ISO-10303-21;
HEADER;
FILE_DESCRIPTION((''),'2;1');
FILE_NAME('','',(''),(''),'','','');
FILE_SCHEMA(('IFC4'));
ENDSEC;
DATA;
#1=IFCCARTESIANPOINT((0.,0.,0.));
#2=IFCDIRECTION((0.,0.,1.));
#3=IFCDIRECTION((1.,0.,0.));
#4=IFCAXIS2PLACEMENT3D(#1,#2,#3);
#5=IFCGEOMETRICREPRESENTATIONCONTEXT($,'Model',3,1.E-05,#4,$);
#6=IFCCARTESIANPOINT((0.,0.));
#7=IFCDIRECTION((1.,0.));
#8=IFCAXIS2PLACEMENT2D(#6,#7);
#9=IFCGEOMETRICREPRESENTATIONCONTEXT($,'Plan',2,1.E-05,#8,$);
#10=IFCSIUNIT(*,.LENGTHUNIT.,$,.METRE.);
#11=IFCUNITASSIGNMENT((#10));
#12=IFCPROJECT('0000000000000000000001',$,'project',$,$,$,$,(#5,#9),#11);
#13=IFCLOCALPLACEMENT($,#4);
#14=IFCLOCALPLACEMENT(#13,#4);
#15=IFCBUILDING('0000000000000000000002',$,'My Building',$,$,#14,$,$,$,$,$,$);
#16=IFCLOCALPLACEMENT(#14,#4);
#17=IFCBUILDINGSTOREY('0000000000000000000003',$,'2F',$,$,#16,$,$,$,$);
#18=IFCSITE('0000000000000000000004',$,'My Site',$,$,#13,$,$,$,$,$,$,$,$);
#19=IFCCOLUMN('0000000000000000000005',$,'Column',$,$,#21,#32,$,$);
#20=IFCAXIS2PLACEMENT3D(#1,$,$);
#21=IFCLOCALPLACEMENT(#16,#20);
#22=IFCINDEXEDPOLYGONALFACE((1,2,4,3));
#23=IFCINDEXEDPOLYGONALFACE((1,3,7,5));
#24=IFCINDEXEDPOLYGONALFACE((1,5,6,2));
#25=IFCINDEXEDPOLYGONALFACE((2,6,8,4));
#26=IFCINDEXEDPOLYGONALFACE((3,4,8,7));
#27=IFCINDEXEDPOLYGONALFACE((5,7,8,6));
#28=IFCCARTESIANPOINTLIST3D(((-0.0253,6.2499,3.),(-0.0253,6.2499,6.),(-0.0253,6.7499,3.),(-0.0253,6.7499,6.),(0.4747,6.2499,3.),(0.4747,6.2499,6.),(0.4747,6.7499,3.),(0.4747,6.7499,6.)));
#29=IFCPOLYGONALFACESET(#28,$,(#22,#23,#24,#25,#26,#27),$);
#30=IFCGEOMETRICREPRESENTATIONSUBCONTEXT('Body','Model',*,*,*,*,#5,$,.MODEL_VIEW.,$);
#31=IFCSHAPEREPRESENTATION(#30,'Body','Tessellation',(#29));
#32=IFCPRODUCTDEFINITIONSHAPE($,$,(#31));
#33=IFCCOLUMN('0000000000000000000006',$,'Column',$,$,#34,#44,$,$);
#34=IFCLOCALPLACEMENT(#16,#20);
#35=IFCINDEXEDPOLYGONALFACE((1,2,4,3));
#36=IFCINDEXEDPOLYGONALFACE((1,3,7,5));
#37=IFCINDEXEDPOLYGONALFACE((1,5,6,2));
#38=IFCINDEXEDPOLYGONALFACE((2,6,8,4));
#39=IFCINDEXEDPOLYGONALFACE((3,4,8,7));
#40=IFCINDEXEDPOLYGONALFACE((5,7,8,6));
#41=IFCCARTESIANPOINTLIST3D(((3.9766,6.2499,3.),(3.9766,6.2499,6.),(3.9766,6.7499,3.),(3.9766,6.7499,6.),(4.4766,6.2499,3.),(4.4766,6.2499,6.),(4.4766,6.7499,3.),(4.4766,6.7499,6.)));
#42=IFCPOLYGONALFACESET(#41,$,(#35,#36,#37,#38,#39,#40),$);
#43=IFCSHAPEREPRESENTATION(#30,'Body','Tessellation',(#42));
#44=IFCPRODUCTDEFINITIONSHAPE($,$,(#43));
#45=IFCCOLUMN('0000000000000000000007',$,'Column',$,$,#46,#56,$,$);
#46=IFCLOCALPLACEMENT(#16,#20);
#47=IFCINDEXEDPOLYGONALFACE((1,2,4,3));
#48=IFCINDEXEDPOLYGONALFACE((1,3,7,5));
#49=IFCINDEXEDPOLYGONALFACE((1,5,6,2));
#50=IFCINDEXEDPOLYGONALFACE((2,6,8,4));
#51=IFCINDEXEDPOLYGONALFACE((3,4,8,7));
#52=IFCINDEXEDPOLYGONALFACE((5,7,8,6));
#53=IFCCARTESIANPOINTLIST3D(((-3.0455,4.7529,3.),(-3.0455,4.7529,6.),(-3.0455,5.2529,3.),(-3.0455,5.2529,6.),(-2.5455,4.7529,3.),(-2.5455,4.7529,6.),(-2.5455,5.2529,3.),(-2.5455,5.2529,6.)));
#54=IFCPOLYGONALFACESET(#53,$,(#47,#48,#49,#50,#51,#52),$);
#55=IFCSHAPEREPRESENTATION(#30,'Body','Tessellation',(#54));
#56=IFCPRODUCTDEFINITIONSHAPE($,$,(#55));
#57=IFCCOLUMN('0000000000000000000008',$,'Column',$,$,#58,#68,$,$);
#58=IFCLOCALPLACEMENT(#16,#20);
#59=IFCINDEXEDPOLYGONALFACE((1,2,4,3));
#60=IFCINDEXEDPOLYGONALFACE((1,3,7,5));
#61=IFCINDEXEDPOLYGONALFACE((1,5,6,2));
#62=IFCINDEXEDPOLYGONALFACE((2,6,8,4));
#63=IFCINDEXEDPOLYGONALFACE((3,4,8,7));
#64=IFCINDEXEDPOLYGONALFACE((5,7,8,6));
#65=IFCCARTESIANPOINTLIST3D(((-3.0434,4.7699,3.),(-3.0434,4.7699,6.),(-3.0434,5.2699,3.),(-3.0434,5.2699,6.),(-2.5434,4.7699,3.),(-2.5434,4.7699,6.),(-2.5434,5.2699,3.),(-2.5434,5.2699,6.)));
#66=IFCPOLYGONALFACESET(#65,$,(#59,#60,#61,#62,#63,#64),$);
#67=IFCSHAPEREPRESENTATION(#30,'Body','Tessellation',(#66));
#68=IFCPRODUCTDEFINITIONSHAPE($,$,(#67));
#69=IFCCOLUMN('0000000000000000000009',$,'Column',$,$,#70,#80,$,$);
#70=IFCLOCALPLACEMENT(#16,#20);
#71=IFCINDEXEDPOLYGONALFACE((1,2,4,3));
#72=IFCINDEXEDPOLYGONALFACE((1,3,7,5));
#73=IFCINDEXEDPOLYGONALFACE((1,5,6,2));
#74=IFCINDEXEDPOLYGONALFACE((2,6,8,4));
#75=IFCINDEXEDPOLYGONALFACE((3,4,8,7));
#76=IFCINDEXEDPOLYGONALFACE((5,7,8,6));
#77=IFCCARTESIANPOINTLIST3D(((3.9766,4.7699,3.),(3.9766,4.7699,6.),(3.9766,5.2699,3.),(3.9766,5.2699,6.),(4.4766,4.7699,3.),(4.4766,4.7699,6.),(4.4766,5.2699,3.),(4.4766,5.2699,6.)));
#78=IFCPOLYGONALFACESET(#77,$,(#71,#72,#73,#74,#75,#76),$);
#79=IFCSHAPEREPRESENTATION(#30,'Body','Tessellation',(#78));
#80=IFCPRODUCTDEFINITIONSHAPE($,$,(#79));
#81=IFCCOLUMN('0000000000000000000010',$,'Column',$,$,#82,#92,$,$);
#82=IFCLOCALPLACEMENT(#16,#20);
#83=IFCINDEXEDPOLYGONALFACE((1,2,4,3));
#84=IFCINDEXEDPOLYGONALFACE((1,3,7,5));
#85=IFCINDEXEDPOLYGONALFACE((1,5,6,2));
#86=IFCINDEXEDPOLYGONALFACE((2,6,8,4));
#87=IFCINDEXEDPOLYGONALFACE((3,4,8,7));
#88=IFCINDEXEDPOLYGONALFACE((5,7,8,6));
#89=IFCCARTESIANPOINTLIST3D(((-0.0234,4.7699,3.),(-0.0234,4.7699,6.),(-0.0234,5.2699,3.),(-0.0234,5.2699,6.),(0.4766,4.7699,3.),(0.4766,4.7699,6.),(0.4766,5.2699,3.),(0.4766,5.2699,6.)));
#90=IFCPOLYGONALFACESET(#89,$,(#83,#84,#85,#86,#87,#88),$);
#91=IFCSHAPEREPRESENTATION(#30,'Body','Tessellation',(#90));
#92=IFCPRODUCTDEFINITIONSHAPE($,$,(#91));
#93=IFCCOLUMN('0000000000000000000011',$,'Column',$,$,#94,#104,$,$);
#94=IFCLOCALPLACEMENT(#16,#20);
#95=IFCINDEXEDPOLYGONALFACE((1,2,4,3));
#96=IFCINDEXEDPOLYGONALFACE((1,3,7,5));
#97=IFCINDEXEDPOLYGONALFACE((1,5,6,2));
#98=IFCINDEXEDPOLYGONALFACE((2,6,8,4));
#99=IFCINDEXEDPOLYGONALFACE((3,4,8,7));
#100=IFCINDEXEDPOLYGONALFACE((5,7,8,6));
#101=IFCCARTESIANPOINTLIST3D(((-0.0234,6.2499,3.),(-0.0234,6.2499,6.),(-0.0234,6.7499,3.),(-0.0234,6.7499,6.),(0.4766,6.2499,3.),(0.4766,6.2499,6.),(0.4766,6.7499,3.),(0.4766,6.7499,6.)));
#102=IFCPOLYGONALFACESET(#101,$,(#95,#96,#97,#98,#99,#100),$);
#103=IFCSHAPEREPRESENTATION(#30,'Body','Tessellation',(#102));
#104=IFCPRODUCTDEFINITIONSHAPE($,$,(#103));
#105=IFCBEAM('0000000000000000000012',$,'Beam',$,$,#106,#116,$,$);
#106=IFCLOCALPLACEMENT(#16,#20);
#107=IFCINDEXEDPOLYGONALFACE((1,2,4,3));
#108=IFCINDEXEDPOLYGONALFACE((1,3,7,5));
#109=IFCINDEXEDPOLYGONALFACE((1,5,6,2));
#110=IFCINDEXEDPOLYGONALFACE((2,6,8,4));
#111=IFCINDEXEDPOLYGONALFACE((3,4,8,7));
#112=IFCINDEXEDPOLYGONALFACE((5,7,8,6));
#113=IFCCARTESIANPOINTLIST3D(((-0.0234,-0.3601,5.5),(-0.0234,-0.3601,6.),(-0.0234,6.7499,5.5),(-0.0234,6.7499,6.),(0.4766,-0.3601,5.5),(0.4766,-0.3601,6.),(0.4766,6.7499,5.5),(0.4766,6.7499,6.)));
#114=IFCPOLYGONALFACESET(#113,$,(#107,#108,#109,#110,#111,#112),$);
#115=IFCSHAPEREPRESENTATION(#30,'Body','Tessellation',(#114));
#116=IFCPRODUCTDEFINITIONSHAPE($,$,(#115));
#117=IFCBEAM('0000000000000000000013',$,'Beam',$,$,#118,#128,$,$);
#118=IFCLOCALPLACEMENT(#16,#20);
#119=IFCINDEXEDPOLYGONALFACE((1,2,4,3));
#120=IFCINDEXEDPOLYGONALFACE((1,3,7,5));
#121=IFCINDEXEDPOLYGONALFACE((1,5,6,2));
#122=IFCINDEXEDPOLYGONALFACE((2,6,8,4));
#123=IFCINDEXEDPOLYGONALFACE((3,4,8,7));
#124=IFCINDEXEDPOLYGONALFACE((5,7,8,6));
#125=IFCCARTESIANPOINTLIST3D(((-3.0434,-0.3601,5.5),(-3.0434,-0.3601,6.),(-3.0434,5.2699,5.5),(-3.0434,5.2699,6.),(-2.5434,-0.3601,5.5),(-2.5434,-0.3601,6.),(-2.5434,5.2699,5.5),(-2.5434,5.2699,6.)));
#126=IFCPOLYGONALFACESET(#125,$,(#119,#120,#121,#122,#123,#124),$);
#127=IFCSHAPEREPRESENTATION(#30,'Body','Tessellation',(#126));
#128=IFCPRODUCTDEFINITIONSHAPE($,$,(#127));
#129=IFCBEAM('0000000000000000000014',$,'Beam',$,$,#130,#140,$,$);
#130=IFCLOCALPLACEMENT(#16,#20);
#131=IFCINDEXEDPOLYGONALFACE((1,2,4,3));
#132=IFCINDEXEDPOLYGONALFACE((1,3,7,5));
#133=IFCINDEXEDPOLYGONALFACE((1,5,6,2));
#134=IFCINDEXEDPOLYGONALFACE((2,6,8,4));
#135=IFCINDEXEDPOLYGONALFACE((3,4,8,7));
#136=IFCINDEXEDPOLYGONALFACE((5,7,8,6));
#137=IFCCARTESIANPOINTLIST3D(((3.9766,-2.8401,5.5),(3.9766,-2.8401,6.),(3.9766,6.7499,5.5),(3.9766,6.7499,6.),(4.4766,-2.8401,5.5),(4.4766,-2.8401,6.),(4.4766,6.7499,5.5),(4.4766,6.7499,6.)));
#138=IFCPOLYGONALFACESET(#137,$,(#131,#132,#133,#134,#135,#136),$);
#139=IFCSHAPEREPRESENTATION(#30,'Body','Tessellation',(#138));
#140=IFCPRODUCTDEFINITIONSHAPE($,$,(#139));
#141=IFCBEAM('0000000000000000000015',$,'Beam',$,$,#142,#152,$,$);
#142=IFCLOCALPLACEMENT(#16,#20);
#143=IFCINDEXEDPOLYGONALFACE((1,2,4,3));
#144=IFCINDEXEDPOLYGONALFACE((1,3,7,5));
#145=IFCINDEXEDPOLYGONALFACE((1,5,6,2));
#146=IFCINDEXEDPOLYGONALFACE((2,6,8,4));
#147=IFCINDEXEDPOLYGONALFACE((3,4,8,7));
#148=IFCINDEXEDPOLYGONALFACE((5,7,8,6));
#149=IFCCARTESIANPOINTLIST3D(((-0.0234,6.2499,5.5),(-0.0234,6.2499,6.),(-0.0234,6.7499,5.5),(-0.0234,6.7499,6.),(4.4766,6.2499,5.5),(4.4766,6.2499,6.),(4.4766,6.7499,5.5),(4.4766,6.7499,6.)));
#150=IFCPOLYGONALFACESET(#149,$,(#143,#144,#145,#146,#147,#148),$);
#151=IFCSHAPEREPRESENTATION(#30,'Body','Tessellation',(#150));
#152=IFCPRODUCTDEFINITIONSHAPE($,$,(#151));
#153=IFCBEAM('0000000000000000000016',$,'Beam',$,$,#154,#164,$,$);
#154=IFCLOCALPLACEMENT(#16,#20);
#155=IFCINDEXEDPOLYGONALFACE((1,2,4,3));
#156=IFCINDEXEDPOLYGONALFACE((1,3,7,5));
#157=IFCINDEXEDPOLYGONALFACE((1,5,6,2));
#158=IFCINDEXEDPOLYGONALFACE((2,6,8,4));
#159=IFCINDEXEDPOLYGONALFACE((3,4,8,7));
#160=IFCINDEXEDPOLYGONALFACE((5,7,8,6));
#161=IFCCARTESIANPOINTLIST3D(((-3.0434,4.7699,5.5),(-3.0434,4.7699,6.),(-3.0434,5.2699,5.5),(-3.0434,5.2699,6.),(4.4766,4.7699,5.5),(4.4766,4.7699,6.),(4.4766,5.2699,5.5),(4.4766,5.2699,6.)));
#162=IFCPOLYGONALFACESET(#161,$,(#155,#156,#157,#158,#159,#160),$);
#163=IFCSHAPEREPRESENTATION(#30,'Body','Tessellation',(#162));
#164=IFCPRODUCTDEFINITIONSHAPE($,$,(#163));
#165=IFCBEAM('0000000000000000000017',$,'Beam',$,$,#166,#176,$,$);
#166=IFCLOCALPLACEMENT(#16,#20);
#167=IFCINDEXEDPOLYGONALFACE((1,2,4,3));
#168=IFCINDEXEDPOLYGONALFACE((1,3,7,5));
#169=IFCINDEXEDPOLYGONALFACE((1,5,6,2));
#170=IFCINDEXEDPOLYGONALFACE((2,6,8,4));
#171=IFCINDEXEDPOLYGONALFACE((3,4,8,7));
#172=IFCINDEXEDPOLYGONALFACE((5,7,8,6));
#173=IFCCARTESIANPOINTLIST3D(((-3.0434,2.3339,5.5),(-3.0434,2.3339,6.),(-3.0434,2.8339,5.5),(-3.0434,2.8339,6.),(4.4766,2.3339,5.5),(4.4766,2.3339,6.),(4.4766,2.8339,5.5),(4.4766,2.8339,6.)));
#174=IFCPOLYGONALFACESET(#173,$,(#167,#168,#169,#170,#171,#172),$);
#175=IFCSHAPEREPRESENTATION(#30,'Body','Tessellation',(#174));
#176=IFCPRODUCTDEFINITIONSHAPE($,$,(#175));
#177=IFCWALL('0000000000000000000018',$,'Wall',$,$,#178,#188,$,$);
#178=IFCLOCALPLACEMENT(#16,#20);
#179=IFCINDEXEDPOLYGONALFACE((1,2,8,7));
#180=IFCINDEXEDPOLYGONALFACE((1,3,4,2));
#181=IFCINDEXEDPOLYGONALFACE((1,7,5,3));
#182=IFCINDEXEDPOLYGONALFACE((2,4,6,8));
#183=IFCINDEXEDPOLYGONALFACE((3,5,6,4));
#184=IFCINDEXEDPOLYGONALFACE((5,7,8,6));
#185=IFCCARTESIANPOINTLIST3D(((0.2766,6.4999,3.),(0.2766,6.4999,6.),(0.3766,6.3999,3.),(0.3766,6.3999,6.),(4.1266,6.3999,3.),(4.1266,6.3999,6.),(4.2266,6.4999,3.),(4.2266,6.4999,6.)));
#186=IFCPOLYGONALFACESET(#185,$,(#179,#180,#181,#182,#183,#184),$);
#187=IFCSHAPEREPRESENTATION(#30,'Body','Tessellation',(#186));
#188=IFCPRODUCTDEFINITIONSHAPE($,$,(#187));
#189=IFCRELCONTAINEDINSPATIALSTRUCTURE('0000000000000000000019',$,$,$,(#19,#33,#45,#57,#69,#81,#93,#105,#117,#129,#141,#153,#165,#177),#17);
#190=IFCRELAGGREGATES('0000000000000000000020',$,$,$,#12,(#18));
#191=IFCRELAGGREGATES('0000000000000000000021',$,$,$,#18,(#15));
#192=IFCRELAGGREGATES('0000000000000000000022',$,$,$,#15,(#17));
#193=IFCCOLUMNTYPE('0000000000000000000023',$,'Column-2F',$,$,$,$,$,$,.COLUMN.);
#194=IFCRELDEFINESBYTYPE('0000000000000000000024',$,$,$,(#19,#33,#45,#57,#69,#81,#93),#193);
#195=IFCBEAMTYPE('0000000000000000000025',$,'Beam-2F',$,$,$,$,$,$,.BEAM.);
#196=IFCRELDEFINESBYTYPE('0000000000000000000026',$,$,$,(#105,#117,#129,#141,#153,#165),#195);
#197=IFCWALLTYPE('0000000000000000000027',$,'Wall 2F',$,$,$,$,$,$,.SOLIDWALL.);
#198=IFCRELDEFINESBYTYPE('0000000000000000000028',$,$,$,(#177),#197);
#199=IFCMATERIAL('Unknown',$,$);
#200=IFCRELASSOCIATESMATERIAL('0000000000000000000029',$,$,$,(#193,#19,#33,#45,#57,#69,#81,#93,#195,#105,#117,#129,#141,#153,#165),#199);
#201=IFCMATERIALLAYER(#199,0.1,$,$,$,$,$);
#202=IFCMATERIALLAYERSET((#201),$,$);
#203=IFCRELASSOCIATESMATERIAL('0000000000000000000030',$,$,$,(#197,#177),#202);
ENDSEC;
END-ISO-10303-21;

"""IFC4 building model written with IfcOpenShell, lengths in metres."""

from ifc_helpers import new_model, si_unit, frame, origin_with_axes, origin_2d_with_axis, place, context, subcontext, project, spatial, line, indexed_curve, rectangle, outline, extrude, material, layer, layer_set, layer_usage, material_profile, profile_set, profile_usage, type_object, element, save


model = new_model("IFC4")

# Units and contexts
model_context = context("Model", 3, precision=1e-05, world=origin_with_axes())
plan_context = context("Plan", 2, precision=1e-05, world=origin_2d_with_axis())
body_context_1 = subcontext(model_context, "Body", "Model", "MODEL_VIEW")
ifc_project = project(units=[si_unit("LENGTHUNIT", "METRE")], contexts=[model_context, plan_context])

# Site, building, storey
site_placement = place(None, origin_with_axes())
site = spatial("IfcSite", under=ifc_project, at=site_placement, Name="My Site")
building_placement = place(site_placement, origin_with_axes())
building = spatial("IfcBuilding", under=site, at=building_placement, Name="My Building")
storey_placement = place(building_placement, origin_with_axes())
storey = spatial("IfcBuildingStorey", under=building, at=storey_placement, Name="2F")

# Columns
ifc_material = material(Name="Unknown")
ifc_material_profile_1 = material_profile(ifc_material, rectangle(XDim=0.5, YDim=0.5))
ifc_profile_set_1 = profile_set([ifc_material_profile_1])
ifc_profile_usage_1 = profile_usage(ifc_profile_set_1, cardinal=7)
column_type = type_object("IfcColumnType", Name="Column-2F", PredefinedType="COLUMN", material=ifc_profile_set_1)
column_1_placement = place(storey_placement, frame((0.4747, 6.7499, 3.0), z_axis=(0.0, 0.0, 1.0), x_axis=(1.0, 0.0, 0.0)))
element("IfcColumn", 1, at=column_1_placement, inside=storey, type_object=column_type, material=ifc_profile_usage_1, Name="Column", context=body_context_1, shape_type="SweptSolid", body=[
    extrude(rectangle(XDim=0.5, YDim=0.5), frame((-0.25, -0.25, 0.0), z_axis=(0.0, 0.0, 1.0), x_axis=(1.0, 0.0, 0.0)), (0.0, 0.0, 1.0), 3.0),
])
ifc_profile_usage_2 = profile_usage(ifc_profile_set_1, cardinal=7)
column_2_placement = place(storey_placement, frame((4.4766, 6.7499, 3.0), z_axis=(0.0, 0.0, 1.0), x_axis=(1.0, 0.0, 0.0)))
element("IfcColumn", 2, at=column_2_placement, inside=storey, type_object=column_type, material=ifc_profile_usage_2, Name="Column", context=body_context_1, shape_type="SweptSolid", body=[
    extrude(rectangle(XDim=0.5, YDim=0.5), frame((-0.25, -0.25, 0.0), z_axis=(0.0, 0.0, 1.0), x_axis=(1.0, 0.0, 0.0)), (0.0, 0.0, 1.0), 3.0),
])
ifc_profile_usage_3 = profile_usage(ifc_profile_set_1, cardinal=7)
column_3_placement = place(storey_placement, frame((-2.5455, 5.2529, 3.0), z_axis=(0.0, 0.0, 1.0), x_axis=(1.0, 0.0, 0.0)))
element("IfcColumn", 3, at=column_3_placement, inside=storey, type_object=column_type, material=ifc_profile_usage_3, Name="Column", context=body_context_1, shape_type="SweptSolid", body=[
    extrude(rectangle(XDim=0.5, YDim=0.5), frame((-0.25, -0.25, 0.0), z_axis=(0.0, 0.0, 1.0), x_axis=(1.0, 0.0, 0.0)), (0.0, 0.0, 1.0), 3.0),
])
ifc_profile_usage_4 = profile_usage(ifc_profile_set_1, cardinal=7)
column_4_placement = place(storey_placement, frame((-2.5434, 5.2699, 3.0), z_axis=(0.0, 0.0, 1.0), x_axis=(1.0, 0.0, 0.0)))
element("IfcColumn", 4, at=column_4_placement, inside=storey, type_object=column_type, material=ifc_profile_usage_4, Name="Column", context=body_context_1, shape_type="SweptSolid", body=[
    extrude(rectangle(XDim=0.5, YDim=0.5), frame((-0.25, -0.25, 0.0), z_axis=(0.0, 0.0, 1.0), x_axis=(1.0, 0.0, 0.0)), (0.0, 0.0, 1.0), 3.0),
])
ifc_profile_usage_5 = profile_usage(ifc_profile_set_1, cardinal=7)
column_5_placement = place(storey_placement, frame((4.4766, 5.2699, 3.0), z_axis=(0.0, 0.0, 1.0), x_axis=(1.0, 0.0, 0.0)))
element("IfcColumn", 5, at=column_5_placement, inside=storey, type_object=column_type, material=ifc_profile_usage_5, Name="Column", context=body_context_1, shape_type="SweptSolid", body=[
    extrude(rectangle(XDim=0.5, YDim=0.5), frame((-0.25, -0.25, 0.0), z_axis=(0.0, 0.0, 1.0), x_axis=(1.0, 0.0, 0.0)), (0.0, 0.0, 1.0), 3.0),
])
ifc_profile_usage_6 = profile_usage(ifc_profile_set_1, cardinal=7)
column_6_placement = place(storey_placement, frame((0.4766, 5.2699, 3.0), z_axis=(0.0, 0.0, 1.0), x_axis=(1.0, 0.0, 0.0)))
element("IfcColumn", 6, at=column_6_placement, inside=storey, type_object=column_type, material=ifc_profile_usage_6, Name="Column", context=body_context_1, shape_type="SweptSolid", body=[
    extrude(rectangle(XDim=0.5, YDim=0.5), frame((-0.25, -0.25, 0.0), z_axis=(0.0, 0.0, 1.0), x_axis=(1.0, 0.0, 0.0)), (0.0, 0.0, 1.0), 3.0),
])
ifc_profile_usage_7 = profile_usage(ifc_profile_set_1, cardinal=7)
column_7_placement = place(storey_placement, frame((0.4766, 6.7499, 3.0), z_axis=(0.0, 0.0, 1.0), x_axis=(1.0, 0.0, 0.0)))
element("IfcColumn", 7, at=column_7_placement, inside=storey, type_object=column_type, material=ifc_profile_usage_7, Name="Column", context=body_context_1, shape_type="SweptSolid", body=[
    extrude(rectangle(XDim=0.5, YDim=0.5), frame((-0.25, -0.25, 0.0), z_axis=(0.0, 0.0, 1.0), x_axis=(1.0, 0.0, 0.0)), (0.0, 0.0, 1.0), 3.0),
])

# Beams
ifc_material_profile_2 = material_profile(ifc_material, rectangle(XDim=0.5, YDim=0.5))
ifc_profile_set_2 = profile_set([ifc_material_profile_2])
ifc_profile_usage_8 = profile_usage(ifc_profile_set_2, cardinal=7)
beam_type = type_object("IfcBeamType", Name="Beam-2F", PredefinedType="BEAM", material=ifc_profile_set_2)
beam_1_placement = place(storey_placement, frame((0.4766, 6.7499, 6.0), z_axis=(0.0, -1.0, 0.0), x_axis=(1.0, 0.0, 0.0)))
element("IfcBeam", 8, at=beam_1_placement, inside=storey, type_object=beam_type, material=ifc_profile_usage_8, Name="Beam", context=body_context_1, shape_type="SweptSolid", body=[
    extrude(rectangle(XDim=0.5, YDim=0.5), frame((-0.25, -0.25, 0.0), z_axis=(0.0, 0.0, 1.0), x_axis=(1.0, 0.0, 0.0)), (0.0, 0.0, 1.0), 7.11),
])
ifc_profile_usage_9 = profile_usage(ifc_profile_set_2, cardinal=7)
beam_2_placement = place(storey_placement, frame((-2.5434, 5.2699, 6.0), z_axis=(0.0, -1.0, 0.0), x_axis=(1.0, 0.0, 0.0)))
element("IfcBeam", 9, at=beam_2_placement, inside=storey, type_object=beam_type, material=ifc_profile_usage_9, Name="Beam", context=body_context_1, shape_type="SweptSolid", body=[
    extrude(rectangle(XDim=0.5, YDim=0.5), frame((-0.25, -0.25, 0.0), z_axis=(0.0, 0.0, 1.0), x_axis=(1.0, 0.0, 0.0)), (0.0, 0.0, 1.0), 5.63),
])
ifc_profile_usage_10 = profile_usage(ifc_profile_set_2, cardinal=7)
beam_3_placement = place(storey_placement, frame((4.4766, 6.7499, 6.0), z_axis=(0.0, -1.0, 0.0), x_axis=(1.0, 0.0, 0.0)))
element("IfcBeam", 10, at=beam_3_placement, inside=storey, type_object=beam_type, material=ifc_profile_usage_10, Name="Beam", context=body_context_1, shape_type="SweptSolid", body=[
    extrude(rectangle(XDim=0.5, YDim=0.5), frame((-0.25, -0.25, 0.0), z_axis=(0.0, 0.0, 1.0), x_axis=(1.0, 0.0, 0.0)), (0.0, 0.0, 1.0), 9.59),
])
ifc_profile_usage_11 = profile_usage(ifc_profile_set_2, cardinal=7)
beam_4_placement = place(storey_placement, frame((-0.0234, 6.7499, 6.0), z_axis=(1.0, 0.0, 0.0), x_axis=(0.0, 1.0, 0.0)))
element("IfcBeam", 11, at=beam_4_placement, inside=storey, type_object=beam_type, material=ifc_profile_usage_11, Name="Beam", context=body_context_1, shape_type="SweptSolid", body=[
    extrude(rectangle(XDim=0.5, YDim=0.5), frame((-0.25, -0.25, 0.0), z_axis=(0.0, 0.0, 1.0), x_axis=(1.0, 0.0, 0.0)), (0.0, 0.0, 1.0), 4.5),
])
ifc_profile_usage_12 = profile_usage(ifc_profile_set_2, cardinal=7)
beam_5_placement = place(storey_placement, frame((-3.0434, 5.2699, 6.0), z_axis=(1.0, 0.0, 0.0), x_axis=(0.0, 1.0, 0.0)))
element("IfcBeam", 12, at=beam_5_placement, inside=storey, type_object=beam_type, material=ifc_profile_usage_12, Name="Beam", context=body_context_1, shape_type="SweptSolid", body=[
    extrude(rectangle(XDim=0.5, YDim=0.5), frame((-0.25, -0.25, 0.0), z_axis=(0.0, 0.0, 1.0), x_axis=(1.0, 0.0, 0.0)), (0.0, 0.0, 1.0), 7.52),
])
ifc_profile_usage_13 = profile_usage(ifc_profile_set_2, cardinal=7)
beam_6_placement = place(storey_placement, frame((-3.0434, 2.8339, 6.0), z_axis=(1.0, -0.000001, 0.000001), x_axis=(0.000001, 1.0, 0.0)))
element("IfcBeam", 13, at=beam_6_placement, inside=storey, type_object=beam_type, material=ifc_profile_usage_13, Name="Beam", context=body_context_1, shape_type="SweptSolid", body=[
    extrude(rectangle(XDim=0.5, YDim=0.5), frame((-0.25, -0.25, 0.0), z_axis=(0.0, 0.0, 1.0), x_axis=(1.0, 0.0, 0.0)), (0.0, 0.0, 1.0), 7.52),
])

# Wall
ifc_layer = layer(ifc_material, 0.1)
ifc_layer_set = layer_set([ifc_layer])
ifc_layer_usage_1 = layer_usage(ifc_layer_set, "AXIS2", "POSITIVE", 0.0)
wall_type = type_object("IfcWallType", Name="Wall 2F", PredefinedType="SOLIDWALL", material=ifc_layer_set)
wall_1_placement = place(storey_placement, frame((4.2266, 6.4999, 3.0), z_axis=(0.0, 0.0, 1.0), x_axis=(-1.0, 0.0, 0.0)))
element("IfcWall", 14, at=wall_1_placement, inside=storey, type_object=wall_type, material=ifc_layer_usage_1, Name="Wall", context=body_context_1, shape_type="SweptSolid", body=[
    extrude(outline(indexed_curve([(0.0, 0.0), (0.1, 0.1), (3.85, 0.1), (3.95, 0.0)], segments=[line(1, 2, 3, 4, 1)])), origin_with_axes(), (0.0, 0.0, 1.0), 3.0),
])

save(model, "model.ifc")
